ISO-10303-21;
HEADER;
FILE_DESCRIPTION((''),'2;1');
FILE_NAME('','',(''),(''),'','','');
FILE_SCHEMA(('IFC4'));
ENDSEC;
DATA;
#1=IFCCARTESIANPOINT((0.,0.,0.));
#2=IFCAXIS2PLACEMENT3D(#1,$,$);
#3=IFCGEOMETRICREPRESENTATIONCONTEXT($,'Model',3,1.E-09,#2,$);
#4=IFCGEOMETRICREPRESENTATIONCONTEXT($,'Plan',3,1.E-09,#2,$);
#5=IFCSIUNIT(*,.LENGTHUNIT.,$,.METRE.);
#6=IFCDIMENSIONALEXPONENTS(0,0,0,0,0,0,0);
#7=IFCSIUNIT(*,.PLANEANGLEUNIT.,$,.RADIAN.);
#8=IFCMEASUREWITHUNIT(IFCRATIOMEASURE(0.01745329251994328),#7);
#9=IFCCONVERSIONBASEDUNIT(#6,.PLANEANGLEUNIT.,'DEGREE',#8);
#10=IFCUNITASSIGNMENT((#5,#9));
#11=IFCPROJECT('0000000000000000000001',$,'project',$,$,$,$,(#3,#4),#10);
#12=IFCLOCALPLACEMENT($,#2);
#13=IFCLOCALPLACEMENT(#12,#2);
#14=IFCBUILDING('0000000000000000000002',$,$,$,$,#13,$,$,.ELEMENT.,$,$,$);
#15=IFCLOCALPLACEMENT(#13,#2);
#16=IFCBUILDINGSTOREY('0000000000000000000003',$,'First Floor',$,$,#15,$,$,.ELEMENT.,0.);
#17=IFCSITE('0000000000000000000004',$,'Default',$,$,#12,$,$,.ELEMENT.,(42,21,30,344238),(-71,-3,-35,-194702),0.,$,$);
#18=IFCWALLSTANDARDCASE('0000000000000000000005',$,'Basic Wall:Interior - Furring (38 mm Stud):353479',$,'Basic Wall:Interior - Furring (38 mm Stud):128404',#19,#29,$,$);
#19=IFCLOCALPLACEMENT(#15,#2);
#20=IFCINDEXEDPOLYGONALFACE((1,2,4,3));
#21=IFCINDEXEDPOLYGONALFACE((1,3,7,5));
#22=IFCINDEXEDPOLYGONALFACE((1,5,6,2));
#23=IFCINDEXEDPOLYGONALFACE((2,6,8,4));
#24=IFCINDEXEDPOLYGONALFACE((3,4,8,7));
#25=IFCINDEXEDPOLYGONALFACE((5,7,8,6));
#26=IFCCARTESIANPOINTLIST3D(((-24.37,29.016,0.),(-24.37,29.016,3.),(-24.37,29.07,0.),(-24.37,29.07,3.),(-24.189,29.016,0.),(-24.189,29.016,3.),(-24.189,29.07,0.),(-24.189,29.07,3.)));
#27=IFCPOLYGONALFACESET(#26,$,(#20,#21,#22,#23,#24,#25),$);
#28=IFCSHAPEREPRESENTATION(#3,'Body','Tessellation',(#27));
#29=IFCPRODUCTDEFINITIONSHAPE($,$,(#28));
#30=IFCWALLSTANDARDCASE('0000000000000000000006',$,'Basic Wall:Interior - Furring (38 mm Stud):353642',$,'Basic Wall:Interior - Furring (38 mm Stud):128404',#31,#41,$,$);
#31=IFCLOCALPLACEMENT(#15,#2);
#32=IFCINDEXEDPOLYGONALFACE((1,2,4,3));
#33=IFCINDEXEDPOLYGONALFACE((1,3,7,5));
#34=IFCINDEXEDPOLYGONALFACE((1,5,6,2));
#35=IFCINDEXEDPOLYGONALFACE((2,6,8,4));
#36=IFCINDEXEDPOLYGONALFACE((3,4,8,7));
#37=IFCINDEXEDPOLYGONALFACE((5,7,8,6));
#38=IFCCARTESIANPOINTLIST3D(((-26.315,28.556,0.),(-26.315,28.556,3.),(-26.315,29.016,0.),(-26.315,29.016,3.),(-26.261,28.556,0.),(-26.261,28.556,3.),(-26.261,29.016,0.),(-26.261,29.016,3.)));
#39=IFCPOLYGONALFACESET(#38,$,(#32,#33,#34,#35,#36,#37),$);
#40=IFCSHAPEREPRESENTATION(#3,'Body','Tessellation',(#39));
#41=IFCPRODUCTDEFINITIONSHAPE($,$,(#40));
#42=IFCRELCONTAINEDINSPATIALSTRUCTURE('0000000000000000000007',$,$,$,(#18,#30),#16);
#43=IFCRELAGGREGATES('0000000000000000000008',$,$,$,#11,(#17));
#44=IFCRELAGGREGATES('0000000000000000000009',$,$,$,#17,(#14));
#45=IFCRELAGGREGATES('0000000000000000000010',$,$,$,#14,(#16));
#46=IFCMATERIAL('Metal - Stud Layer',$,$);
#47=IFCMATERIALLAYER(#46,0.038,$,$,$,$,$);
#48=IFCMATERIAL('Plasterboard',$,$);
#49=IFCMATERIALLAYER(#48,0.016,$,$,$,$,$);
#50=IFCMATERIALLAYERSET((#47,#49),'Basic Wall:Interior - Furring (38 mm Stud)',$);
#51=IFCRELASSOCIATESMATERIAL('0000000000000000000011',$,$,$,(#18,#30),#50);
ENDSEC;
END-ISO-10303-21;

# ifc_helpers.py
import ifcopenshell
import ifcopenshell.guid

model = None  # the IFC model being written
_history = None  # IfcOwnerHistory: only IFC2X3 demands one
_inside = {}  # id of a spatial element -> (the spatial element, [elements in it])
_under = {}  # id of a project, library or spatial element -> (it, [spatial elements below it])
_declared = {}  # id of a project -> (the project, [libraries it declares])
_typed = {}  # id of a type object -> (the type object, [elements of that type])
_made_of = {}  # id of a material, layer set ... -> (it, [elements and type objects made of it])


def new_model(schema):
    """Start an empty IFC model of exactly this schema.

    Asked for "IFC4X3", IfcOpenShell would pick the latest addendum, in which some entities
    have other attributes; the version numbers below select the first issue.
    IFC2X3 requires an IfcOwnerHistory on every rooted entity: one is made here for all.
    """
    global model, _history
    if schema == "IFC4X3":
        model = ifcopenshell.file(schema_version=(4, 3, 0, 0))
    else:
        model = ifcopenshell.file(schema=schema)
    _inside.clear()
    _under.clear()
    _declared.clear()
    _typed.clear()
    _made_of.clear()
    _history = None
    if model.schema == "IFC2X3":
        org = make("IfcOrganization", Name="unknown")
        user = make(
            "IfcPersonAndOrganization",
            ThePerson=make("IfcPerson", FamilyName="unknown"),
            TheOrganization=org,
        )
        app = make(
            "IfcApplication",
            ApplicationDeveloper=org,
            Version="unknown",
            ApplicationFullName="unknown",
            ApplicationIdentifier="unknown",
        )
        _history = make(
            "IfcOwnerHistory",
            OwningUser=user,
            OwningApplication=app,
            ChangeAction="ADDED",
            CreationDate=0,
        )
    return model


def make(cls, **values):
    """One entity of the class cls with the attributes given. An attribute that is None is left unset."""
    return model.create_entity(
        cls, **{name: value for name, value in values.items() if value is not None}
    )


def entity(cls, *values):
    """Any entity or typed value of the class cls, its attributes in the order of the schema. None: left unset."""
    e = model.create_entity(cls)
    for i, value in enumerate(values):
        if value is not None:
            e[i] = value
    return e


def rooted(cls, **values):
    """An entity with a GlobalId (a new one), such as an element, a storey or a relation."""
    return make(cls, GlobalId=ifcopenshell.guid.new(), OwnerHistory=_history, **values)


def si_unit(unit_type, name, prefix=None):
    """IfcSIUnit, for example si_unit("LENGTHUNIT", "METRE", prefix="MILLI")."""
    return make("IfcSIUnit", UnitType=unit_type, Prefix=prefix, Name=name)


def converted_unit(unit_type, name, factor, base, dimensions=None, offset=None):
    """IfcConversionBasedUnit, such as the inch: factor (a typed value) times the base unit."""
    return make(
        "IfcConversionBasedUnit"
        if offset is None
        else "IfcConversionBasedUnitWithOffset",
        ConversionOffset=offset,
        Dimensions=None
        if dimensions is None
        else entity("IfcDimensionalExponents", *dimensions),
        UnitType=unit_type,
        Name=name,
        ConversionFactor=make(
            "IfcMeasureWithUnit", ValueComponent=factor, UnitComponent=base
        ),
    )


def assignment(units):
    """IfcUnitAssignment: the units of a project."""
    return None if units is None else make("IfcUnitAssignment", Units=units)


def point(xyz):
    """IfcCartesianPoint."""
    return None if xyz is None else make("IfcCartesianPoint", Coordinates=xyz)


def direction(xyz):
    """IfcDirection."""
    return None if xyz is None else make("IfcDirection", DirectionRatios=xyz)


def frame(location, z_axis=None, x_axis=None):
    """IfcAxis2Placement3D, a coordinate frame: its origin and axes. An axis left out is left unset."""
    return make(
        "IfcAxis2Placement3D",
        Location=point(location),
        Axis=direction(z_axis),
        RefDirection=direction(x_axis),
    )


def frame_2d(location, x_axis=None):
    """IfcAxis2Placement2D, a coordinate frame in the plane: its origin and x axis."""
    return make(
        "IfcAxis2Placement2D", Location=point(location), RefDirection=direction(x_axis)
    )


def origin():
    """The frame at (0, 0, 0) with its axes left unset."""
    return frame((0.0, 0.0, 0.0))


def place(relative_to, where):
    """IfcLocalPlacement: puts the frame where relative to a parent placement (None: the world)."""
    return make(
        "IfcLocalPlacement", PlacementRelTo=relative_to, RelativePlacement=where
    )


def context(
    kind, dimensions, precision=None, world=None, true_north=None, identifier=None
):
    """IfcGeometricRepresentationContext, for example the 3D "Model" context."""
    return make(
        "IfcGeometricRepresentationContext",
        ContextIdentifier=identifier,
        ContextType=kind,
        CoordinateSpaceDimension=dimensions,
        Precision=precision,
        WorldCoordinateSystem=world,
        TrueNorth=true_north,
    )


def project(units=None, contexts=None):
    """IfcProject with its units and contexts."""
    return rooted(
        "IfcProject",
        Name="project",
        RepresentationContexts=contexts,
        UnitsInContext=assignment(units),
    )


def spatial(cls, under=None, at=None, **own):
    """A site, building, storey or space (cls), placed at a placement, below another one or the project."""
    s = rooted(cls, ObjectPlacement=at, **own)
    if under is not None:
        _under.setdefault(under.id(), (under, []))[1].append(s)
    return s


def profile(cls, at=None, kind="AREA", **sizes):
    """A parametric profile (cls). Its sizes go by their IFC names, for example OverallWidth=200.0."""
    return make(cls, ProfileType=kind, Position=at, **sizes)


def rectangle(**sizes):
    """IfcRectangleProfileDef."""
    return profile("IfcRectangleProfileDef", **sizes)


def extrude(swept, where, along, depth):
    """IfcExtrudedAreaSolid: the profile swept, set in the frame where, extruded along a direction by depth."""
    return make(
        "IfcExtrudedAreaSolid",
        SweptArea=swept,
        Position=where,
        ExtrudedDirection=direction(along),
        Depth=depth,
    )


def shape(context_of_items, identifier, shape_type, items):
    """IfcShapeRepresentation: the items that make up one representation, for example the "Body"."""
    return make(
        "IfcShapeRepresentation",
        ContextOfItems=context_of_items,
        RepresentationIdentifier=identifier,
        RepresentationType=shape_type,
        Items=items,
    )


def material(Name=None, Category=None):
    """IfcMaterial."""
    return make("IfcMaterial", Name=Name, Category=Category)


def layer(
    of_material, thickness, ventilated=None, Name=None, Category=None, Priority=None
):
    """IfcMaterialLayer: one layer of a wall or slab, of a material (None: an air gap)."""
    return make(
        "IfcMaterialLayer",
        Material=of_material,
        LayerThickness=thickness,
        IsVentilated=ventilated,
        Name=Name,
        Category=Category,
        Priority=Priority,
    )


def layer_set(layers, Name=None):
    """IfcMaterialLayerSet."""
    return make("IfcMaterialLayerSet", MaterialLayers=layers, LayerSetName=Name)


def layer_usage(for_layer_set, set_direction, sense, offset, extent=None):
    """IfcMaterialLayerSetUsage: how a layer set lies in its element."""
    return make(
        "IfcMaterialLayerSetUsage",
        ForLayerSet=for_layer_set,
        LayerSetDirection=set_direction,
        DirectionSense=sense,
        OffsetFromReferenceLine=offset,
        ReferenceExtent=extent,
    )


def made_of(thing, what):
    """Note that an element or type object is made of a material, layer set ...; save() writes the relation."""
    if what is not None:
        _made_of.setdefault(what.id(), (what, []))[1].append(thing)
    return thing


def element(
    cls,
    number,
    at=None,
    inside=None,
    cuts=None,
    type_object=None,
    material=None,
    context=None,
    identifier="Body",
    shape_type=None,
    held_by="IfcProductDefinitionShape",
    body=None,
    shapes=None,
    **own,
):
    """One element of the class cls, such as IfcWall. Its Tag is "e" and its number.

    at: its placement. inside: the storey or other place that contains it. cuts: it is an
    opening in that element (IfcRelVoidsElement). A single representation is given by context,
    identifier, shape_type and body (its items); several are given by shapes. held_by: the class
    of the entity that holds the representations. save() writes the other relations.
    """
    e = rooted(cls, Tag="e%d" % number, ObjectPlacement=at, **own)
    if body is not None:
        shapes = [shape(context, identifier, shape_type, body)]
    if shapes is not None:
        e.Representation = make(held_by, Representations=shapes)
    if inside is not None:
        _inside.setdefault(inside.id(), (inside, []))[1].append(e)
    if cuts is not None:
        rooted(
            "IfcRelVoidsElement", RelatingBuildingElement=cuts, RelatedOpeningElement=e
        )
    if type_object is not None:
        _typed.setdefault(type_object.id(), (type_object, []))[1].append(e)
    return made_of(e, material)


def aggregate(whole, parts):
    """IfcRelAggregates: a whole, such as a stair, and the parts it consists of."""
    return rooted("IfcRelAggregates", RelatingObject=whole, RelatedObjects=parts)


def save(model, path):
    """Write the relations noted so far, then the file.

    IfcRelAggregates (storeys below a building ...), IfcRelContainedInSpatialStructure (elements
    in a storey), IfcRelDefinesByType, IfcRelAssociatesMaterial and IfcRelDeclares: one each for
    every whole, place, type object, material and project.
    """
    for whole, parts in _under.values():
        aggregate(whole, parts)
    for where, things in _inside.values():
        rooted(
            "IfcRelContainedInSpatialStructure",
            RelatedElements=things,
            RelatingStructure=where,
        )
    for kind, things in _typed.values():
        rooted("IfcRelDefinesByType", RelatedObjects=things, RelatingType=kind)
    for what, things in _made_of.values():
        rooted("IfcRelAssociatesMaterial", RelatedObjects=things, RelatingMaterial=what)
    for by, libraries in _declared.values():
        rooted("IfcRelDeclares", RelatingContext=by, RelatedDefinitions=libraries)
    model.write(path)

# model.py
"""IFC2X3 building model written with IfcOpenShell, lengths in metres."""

from ifc_helpers import new_model, entity, si_unit, converted_unit, frame, frame_2d, origin, place, context, project, spatial, rectangle, extrude, material, layer, layer_set, layer_usage, element, save


model = new_model("IFC2X3")

# Units and contexts
model_context = context("Model", 3, precision=1e-09, world=origin())
plan_context = context("Plan", 3, precision=1e-09, world=origin())
ifc_project = project(units=[si_unit("LENGTHUNIT", "METRE"), converted_unit("PLANEANGLEUNIT", "DEGREE", entity("IfcRatioMeasure", 0.01745329251994328), si_unit("PLANEANGLEUNIT", "RADIAN"), dimensions=[0, 0, 0, 0, 0, 0, 0])], contexts=[model_context, plan_context])

# Site, building, storey
site_placement = place(None, origin())
site = spatial("IfcSite", under=ifc_project, at=site_placement, Name="Default", CompositionType="ELEMENT", RefLatitude=(42, 21, 30, 344238), RefLongitude=(-71, -3, -35, -194702), RefElevation=0.0)
building_placement = place(site_placement, origin())
building = spatial("IfcBuilding", under=site, at=building_placement, CompositionType="ELEMENT")
storey_placement = place(building_placement, origin())
storey = spatial("IfcBuildingStorey", under=building, at=storey_placement, Name="First Floor", CompositionType="ELEMENT", Elevation=0.0)

# Shared definitions
ifc_material_1 = material(Name="Metal - Stud Layer")
ifc_material_2 = material(Name="Plasterboard")

# Walls
ifc_layer_1 = layer(ifc_material_1, 0.038)
ifc_layer_2 = layer(ifc_material_2, 0.016)
ifc_layer_set_1 = layer_set([ifc_layer_1, ifc_layer_2], Name="Basic Wall:Interior - Furring (38 mm Stud)")
ifc_layer_usage_1 = layer_usage(ifc_layer_set_1, "AXIS2", "NEGATIVE", 0.027)
wall_1_placement = place(storey_placement, frame((-24.189, 29.043, 0.0), z_axis=(0.0, 0.0, 1.0), x_axis=(-1.0, 0.0, 0.0)))
element("IfcWallStandardCase", 1, at=wall_1_placement, inside=storey, material=ifc_layer_usage_1, Name="Basic Wall:Interior - Furring (38 mm Stud):353479", ObjectType="Basic Wall:Interior - Furring (38 mm Stud):128404", context=model_context, shape_type="SweptSolid", body=[
    extrude(rectangle(XDim=0.181, YDim=0.054, at=frame_2d((0.0905, 0.0), x_axis=(-1.0, 0.0))), origin(), (0.0, 0.0, 1.0), 3.0),
])
wall_2_placement = place(storey_placement, frame((-26.288, 29.016, 0.0), z_axis=(0.0, 0.0, 1.0), x_axis=(0.0, -1.0, 0.0)))
element("IfcWallStandardCase", 2, at=wall_2_placement, inside=storey, material=ifc_layer_usage_1, Name="Basic Wall:Interior - Furring (38 mm Stud):353642", ObjectType="Basic Wall:Interior - Furring (38 mm Stud):128404", context=model_context, shape_type="SweptSolid", body=[
    extrude(rectangle(XDim=0.46, YDim=0.054, at=frame_2d((0.23, 0.0), x_axis=(-1.0, 0.0))), origin(), (0.0, 0.0, 1.0), 3.0),
])

save(model, "model.ifc")
